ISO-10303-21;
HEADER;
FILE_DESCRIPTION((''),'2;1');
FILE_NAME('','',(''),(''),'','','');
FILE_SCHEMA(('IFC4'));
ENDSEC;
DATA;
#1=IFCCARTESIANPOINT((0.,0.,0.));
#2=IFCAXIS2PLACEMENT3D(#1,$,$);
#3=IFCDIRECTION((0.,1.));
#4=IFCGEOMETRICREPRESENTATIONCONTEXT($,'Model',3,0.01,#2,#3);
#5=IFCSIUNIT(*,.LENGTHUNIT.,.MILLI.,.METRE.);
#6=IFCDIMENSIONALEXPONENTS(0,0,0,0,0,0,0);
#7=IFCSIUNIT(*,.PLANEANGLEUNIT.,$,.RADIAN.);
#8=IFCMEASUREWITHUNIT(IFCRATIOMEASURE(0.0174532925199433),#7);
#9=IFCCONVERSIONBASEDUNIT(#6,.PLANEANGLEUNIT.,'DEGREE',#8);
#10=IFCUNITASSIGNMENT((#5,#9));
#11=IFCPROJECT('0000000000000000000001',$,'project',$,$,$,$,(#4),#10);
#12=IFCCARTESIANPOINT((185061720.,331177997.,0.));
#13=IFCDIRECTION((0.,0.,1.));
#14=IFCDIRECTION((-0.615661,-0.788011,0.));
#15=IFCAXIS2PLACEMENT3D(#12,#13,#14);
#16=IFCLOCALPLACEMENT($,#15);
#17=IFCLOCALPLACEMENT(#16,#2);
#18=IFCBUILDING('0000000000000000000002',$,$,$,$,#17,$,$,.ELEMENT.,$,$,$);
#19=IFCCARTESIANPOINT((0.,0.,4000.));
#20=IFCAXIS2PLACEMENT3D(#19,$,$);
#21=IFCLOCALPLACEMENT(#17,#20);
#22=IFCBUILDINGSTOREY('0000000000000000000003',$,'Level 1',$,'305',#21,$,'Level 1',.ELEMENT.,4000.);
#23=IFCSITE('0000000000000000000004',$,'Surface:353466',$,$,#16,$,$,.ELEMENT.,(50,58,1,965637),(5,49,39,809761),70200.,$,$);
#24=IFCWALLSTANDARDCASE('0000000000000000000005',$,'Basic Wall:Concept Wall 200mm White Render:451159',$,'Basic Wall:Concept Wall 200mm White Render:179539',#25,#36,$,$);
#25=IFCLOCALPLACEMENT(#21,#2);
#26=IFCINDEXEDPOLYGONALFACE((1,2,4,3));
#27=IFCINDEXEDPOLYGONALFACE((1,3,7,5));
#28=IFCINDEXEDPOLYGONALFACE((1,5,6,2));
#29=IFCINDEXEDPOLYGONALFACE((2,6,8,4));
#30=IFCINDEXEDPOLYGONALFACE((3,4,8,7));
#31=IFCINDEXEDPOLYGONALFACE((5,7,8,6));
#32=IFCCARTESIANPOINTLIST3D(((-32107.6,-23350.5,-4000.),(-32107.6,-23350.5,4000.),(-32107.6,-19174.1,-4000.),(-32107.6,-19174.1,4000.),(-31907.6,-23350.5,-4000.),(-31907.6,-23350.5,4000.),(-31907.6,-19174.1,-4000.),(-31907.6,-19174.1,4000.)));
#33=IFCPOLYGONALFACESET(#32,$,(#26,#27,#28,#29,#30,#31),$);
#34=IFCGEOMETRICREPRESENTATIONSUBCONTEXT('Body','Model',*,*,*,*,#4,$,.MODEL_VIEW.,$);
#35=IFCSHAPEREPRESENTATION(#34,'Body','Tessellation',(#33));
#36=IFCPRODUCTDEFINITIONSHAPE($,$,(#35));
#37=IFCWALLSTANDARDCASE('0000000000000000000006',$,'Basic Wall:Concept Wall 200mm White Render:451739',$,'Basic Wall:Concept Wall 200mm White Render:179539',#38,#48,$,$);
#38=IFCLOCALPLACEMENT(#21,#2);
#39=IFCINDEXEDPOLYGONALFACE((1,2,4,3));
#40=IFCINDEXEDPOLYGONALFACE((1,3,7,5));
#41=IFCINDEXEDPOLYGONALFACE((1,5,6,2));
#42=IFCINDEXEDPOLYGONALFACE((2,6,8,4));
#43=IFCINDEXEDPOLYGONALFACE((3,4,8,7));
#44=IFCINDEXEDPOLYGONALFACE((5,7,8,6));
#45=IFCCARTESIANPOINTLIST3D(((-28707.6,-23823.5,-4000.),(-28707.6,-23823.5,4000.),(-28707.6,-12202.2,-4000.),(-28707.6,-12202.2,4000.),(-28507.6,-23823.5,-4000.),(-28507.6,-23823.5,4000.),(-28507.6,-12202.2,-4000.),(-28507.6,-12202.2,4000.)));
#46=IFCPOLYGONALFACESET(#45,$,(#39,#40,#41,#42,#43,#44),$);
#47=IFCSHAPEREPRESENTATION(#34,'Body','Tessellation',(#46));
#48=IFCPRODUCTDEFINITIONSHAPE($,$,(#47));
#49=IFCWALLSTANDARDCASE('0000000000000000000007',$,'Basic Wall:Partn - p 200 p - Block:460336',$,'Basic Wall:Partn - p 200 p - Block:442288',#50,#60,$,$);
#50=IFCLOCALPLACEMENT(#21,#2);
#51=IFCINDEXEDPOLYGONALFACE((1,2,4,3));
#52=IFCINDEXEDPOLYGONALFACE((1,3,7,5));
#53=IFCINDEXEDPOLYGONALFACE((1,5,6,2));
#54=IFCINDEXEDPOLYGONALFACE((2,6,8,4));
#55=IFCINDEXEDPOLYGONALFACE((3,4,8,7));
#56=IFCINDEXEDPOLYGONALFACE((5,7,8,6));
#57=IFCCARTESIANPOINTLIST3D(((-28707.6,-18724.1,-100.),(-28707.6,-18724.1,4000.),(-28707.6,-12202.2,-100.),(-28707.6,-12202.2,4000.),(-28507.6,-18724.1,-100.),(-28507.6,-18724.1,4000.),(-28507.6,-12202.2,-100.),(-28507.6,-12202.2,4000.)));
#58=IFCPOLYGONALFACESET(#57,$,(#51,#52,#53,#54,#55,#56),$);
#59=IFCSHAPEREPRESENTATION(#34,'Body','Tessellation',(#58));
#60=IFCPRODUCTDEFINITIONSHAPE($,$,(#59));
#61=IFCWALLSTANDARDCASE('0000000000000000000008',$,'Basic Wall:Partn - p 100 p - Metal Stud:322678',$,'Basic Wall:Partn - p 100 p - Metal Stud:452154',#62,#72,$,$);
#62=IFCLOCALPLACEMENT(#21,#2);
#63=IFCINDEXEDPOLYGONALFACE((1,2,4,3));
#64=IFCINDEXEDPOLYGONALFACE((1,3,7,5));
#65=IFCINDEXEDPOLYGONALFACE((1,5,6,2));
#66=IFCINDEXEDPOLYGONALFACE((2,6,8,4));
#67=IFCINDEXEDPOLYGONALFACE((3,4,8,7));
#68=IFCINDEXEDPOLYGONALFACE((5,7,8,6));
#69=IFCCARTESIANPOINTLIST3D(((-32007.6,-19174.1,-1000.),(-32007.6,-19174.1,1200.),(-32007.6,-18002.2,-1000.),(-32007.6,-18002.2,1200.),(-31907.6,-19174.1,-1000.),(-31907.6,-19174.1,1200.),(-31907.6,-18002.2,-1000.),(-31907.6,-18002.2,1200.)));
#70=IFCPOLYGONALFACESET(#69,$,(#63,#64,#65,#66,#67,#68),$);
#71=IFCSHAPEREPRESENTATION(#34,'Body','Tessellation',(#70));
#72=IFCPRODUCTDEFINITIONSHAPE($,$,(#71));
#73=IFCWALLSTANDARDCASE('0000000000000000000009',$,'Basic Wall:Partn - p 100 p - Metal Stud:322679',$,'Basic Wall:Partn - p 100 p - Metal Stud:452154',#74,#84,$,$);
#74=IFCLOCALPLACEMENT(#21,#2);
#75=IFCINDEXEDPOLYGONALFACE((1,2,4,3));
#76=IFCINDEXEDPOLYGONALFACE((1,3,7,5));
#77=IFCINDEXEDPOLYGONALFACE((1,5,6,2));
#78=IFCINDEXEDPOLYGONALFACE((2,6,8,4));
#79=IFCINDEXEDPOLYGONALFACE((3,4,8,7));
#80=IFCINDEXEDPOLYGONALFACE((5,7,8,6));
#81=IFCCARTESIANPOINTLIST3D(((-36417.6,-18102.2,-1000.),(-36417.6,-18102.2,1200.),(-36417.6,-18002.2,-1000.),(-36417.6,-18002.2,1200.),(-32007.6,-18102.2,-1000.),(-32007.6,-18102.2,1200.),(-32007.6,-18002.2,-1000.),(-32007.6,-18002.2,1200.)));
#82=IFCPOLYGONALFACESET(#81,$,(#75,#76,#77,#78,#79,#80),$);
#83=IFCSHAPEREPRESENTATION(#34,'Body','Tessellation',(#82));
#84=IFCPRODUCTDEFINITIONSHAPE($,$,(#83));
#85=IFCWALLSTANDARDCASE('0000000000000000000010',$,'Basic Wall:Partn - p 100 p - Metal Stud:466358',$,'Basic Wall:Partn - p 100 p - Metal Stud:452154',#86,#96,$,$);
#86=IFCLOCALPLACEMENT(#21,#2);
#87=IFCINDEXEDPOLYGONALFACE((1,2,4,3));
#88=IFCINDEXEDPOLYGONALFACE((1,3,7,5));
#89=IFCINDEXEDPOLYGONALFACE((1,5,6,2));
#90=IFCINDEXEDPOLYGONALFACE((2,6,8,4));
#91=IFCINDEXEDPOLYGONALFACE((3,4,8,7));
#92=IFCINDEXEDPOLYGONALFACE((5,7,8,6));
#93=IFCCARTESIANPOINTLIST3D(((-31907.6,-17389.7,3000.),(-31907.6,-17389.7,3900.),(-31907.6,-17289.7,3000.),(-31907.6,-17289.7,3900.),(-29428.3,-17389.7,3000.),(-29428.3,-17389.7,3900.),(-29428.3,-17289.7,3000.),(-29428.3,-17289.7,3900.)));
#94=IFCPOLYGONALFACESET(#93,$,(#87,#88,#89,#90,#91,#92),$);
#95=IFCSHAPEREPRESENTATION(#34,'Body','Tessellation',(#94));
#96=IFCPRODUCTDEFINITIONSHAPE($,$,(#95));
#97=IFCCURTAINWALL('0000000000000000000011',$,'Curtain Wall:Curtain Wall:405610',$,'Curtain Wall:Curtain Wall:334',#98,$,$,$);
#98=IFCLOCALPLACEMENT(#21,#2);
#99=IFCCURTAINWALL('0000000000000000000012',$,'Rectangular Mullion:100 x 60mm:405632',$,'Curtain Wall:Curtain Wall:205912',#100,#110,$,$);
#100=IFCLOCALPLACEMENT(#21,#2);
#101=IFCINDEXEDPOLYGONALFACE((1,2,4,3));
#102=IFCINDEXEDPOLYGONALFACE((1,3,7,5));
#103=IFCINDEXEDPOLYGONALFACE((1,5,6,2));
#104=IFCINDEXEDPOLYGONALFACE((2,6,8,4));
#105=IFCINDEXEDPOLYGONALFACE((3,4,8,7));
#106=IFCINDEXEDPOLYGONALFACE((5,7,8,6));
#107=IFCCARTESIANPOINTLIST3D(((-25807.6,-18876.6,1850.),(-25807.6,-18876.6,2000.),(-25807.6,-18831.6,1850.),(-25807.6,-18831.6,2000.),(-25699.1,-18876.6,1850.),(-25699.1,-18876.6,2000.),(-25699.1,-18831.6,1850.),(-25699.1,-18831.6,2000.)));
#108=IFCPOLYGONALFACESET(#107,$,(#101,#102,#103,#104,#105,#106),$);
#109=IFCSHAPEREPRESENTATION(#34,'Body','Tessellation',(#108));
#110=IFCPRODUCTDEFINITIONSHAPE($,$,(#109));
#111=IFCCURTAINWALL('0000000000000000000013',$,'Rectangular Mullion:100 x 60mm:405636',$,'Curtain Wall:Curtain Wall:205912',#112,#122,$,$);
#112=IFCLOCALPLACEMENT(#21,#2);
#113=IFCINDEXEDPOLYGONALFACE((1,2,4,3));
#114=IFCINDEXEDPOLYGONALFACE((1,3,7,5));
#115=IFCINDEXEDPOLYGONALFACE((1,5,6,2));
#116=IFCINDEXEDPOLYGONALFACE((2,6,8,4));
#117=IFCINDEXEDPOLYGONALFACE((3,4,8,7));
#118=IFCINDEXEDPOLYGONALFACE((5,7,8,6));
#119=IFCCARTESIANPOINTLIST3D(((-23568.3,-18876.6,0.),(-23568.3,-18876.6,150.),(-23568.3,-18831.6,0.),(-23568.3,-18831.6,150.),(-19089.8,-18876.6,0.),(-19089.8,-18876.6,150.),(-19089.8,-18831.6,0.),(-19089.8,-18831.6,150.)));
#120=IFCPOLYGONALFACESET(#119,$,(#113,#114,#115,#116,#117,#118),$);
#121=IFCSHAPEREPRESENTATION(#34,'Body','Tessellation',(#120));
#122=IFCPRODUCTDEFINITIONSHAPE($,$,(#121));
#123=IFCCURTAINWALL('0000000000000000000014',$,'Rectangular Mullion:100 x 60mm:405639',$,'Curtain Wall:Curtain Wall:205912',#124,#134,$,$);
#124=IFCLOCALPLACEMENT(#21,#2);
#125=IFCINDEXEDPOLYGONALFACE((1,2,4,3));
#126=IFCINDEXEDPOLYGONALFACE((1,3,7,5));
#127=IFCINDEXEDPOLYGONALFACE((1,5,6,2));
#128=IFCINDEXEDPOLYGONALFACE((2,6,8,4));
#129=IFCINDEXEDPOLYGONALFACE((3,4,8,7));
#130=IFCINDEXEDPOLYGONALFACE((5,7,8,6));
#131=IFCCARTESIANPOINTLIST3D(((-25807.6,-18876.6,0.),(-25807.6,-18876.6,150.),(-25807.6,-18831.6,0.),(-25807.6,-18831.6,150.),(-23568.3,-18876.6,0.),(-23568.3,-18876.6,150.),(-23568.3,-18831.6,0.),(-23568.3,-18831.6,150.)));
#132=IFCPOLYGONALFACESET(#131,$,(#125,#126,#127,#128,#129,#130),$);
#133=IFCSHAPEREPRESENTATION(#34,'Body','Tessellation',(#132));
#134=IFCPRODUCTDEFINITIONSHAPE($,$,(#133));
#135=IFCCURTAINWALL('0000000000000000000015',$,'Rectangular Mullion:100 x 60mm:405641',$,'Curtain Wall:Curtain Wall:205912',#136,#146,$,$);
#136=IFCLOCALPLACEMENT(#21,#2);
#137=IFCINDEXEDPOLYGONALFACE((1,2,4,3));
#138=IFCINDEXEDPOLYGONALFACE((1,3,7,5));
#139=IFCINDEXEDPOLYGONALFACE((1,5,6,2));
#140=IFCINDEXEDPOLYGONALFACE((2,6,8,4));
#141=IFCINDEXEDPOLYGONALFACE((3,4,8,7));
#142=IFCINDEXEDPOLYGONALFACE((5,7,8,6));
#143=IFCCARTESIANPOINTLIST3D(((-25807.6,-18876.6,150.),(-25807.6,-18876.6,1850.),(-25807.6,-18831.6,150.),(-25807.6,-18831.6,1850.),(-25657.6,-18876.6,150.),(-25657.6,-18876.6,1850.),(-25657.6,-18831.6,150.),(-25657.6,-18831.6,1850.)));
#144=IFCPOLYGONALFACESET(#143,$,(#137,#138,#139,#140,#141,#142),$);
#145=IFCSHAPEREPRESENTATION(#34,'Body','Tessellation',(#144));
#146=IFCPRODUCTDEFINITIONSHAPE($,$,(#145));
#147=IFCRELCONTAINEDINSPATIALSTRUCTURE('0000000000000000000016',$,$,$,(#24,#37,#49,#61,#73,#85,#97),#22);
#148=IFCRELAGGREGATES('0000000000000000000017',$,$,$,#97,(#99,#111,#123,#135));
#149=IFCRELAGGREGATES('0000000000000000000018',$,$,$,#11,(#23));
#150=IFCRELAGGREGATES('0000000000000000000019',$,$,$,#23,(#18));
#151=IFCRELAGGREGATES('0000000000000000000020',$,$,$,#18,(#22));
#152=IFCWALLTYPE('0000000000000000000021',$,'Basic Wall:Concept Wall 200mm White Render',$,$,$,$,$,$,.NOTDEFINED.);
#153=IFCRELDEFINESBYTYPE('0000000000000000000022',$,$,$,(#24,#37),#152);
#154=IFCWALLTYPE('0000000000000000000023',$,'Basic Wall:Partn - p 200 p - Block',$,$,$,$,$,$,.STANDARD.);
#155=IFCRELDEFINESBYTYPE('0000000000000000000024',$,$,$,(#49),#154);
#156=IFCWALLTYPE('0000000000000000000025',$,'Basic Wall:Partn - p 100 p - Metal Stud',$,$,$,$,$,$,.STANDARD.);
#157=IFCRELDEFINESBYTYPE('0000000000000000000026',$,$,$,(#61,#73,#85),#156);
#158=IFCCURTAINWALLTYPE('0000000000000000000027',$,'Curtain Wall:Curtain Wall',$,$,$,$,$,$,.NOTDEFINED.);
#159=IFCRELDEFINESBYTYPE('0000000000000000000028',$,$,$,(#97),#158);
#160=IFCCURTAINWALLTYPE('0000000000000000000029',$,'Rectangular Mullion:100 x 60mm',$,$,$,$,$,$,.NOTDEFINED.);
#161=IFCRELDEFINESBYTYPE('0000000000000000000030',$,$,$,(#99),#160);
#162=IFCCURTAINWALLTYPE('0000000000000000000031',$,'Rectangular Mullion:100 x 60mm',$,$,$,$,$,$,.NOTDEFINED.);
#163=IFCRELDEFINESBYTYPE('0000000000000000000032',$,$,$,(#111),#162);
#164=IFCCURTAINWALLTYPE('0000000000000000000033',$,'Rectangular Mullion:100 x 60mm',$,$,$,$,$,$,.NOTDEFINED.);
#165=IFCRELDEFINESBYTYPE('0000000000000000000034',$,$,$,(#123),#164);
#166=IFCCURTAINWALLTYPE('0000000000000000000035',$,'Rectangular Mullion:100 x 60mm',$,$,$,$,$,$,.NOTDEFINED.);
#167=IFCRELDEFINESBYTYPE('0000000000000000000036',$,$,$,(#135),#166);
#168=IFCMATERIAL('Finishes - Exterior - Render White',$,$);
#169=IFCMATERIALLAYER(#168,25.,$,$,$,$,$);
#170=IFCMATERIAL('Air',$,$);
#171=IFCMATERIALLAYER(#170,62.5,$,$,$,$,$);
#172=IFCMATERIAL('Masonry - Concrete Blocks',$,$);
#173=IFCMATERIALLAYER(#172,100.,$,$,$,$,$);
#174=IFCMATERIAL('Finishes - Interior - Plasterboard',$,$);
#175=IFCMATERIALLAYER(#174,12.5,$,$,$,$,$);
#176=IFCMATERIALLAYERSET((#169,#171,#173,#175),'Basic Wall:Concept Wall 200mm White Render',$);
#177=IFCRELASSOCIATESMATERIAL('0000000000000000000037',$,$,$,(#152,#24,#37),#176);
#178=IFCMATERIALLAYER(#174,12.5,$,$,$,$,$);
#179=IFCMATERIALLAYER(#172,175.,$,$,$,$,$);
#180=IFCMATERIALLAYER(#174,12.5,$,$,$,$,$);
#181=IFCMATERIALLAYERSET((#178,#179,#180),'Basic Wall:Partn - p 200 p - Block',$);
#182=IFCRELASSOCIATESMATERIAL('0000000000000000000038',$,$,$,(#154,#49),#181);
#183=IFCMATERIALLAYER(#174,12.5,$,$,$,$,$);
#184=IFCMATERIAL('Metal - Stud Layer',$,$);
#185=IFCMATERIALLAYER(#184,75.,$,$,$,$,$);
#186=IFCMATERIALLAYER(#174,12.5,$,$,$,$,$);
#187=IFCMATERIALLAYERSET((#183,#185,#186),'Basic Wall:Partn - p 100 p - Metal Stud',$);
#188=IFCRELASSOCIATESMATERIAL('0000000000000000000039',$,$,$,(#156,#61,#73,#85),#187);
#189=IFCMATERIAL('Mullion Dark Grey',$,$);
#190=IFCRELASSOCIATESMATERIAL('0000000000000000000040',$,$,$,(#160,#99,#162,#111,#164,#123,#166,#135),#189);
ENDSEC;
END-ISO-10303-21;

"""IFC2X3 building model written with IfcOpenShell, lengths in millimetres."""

from ifc_helpers import new_model, entity, si_unit, converted_unit, direction, frame, frame_2d, origin, place, context, subcontext, project, spatial, rectangle, extrude, clip, halfspace, source, transform, mapped, material, layer, layer_set, layer_usage, type_object, type_shapes, element, aggregate, save


model = new_model("IFC2X3")

# Units and contexts
model_context = context("Model", 3, precision=0.01, world=origin(), true_north=direction((0.0, 1.0)))
body_context = subcontext(model_context, "Body", "Model", "MODEL_VIEW")
ifc_project = project(units=[si_unit("LENGTHUNIT", "METRE", prefix="MILLI"), converted_unit("PLANEANGLEUNIT", "DEGREE", entity("IfcRatioMeasure", 0.0174532925199433), si_unit("PLANEANGLEUNIT", "RADIAN"), dimensions=[0, 0, 0, 0, 0, 0, 0])], contexts=[model_context])

# Site, building, storey
site_placement = place(None, frame((185061720.0, 331177997.0, 0.0), z_axis=(0.0, 0.0, 1.0), x_axis=(-0.615661, -0.788011, 0.0)))
site = spatial("IfcSite", under=ifc_project, at=site_placement, Name="Surface:353466", CompositionType="ELEMENT", RefLatitude=(50, 58, 1, 965637), RefLongitude=(5, 49, 39, 809761), RefElevation=70200.0)
building_placement = place(site_placement, origin())
building = spatial("IfcBuilding", under=site, at=building_placement, CompositionType="ELEMENT")
storey_placement = place(building_placement, frame((0.0, 0.0, 4000.0)))
storey = spatial("IfcBuildingStorey", under=building, at=storey_placement, Name="Level 1", ObjectType="305", LongName="Level 1", CompositionType="ELEMENT", Elevation=4000.0)

# Shared definitions
ifc_material_1 = material(Name="Masonry - Concrete Blocks")
ifc_material_2 = material(Name="Finishes - Interior - Plasterboard")

# Walls
ifc_material_3 = material(Name="Finishes - Exterior - Render White")
ifc_layer_1 = layer(ifc_material_3, 25.0)
ifc_material_4 = material(Name="Air")
ifc_layer_2 = layer(ifc_material_4, 62.5)
ifc_layer_3 = layer(ifc_material_1, 100.0)
ifc_layer_4 = layer(ifc_material_2, 12.5)
ifc_layer_set_1 = layer_set([ifc_layer_1, ifc_layer_2, ifc_layer_3, ifc_layer_4], Name="Basic Wall:Concept Wall 200mm White Render")
ifc_layer_usage_1 = layer_usage(ifc_layer_set_1, "AXIS2", "POSITIVE", -100.0)
wall_type_1 = type_object("IfcWallType", Name="Basic Wall:Concept Wall 200mm White Render", PredefinedType="NOTDEFINED", material=ifc_layer_set_1)
wall_1_placement = place(storey_placement, frame((-32007.6, -19174.1, -4000.0), z_axis=(0.0, 0.0, 1.0), x_axis=(0.0, -1.0, 0.0)))
element("IfcWallStandardCase", 1, at=wall_1_placement, inside=storey, type_object=wall_type_1, material=ifc_layer_usage_1, Name="Basic Wall:Concept Wall 200mm White Render:451159", ObjectType="Basic Wall:Concept Wall 200mm White Render:179539", context=body_context, shape_type="Clipping", body=[
    clip(extrude(rectangle(XDim=4176.4, YDim=200.0, at=frame_2d((2088.2, 0.0), x_axis=(-1.0, 0.0))), origin(), (0.0, 0.0, 1.0), 8000.0), halfspace(frame((0.0, 0.0, -4000.0)), True)),
])
ifc_layer_usage_2 = layer_usage(ifc_layer_set_1, "AXIS2", "POSITIVE", -100.0)
wall_2_placement = place(storey_placement, frame((-28607.6, -23823.5, -4000.0), z_axis=(0.0, 0.0, 1.0), x_axis=(0.0, 1.0, 0.0)))
element("IfcWallStandardCase", 2, at=wall_2_placement, inside=storey, type_object=wall_type_1, material=ifc_layer_usage_2, Name="Basic Wall:Concept Wall 200mm White Render:451739", ObjectType="Basic Wall:Concept Wall 200mm White Render:179539", context=body_context, shape_type="Clipping", body=[
    clip(extrude(rectangle(XDim=11621.2, YDim=200.0, at=frame_2d((5810.6, 0.0), x_axis=(-1.0, 0.0))), origin(), (0.0, 0.0, 1.0), 8000.0), halfspace(frame((0.0, 0.0, -4000.0)), True)),
])
ifc_layer_5 = layer(ifc_material_2, 12.5)
ifc_layer_6 = layer(ifc_material_1, 175.0)
ifc_layer_7 = layer(ifc_material_2, 12.5)
ifc_layer_set_2 = layer_set([ifc_layer_5, ifc_layer_6, ifc_layer_7], Name="Basic Wall:Partn - p 200 p - Block")
ifc_layer_usage_3 = layer_usage(ifc_layer_set_2, "AXIS2", "POSITIVE", -100.0)
wall_type_2 = type_object("IfcWallType", Name="Basic Wall:Partn - p 200 p - Block", PredefinedType="STANDARD", material=ifc_layer_set_2)
wall_3_placement = place(storey_placement, frame((-28607.6, -18724.1, -100.0), z_axis=(0.0, 0.0, 1.0), x_axis=(0.0, 1.0, 0.0)))
element("IfcWallStandardCase", 3, at=wall_3_placement, inside=storey, type_object=wall_type_2, material=ifc_layer_usage_3, Name="Basic Wall:Partn - p 200 p - Block:460336", ObjectType="Basic Wall:Partn - p 200 p - Block:442288", context=body_context, shape_type="Clipping", body=[
    clip(extrude(rectangle(XDim=6521.9, YDim=200.0, at=frame_2d((3261.0, 0.0), x_axis=(-1.0, 0.0))), origin(), (0.0, 0.0, 1.0), 4100.0), halfspace(frame((0.0, 0.0, -100.0)), True)),
])
ifc_layer_8 = layer(ifc_material_2, 12.5)
ifc_material_5 = material(Name="Metal - Stud Layer")
ifc_layer_9 = layer(ifc_material_5, 75.0)
ifc_layer_10 = layer(ifc_material_2, 12.5)
ifc_layer_set_3 = layer_set([ifc_layer_8, ifc_layer_9, ifc_layer_10], Name="Basic Wall:Partn - p 100 p - Metal Stud")
ifc_layer_usage_4 = layer_usage(ifc_layer_set_3, "AXIS2", "NEGATIVE", 50.0)
wall_type_3 = type_object("IfcWallType", Name="Basic Wall:Partn - p 100 p - Metal Stud", PredefinedType="STANDARD", material=ifc_layer_set_3)
wall_4_placement = place(storey_placement, frame((-31957.6, -19174.1, -1000.0), z_axis=(0.0, 0.0, 1.0), x_axis=(0.0, 1.0, 0.0)))
element("IfcWallStandardCase", 4, at=wall_4_placement, inside=storey, type_object=wall_type_3, material=ifc_layer_usage_4, Name="Basic Wall:Partn - p 100 p - Metal Stud:322678", ObjectType="Basic Wall:Partn - p 100 p - Metal Stud:452154", context=body_context, shape_type="SweptSolid", body=[
    extrude(rectangle(XDim=1171.9, YDim=100.0, at=frame_2d((586.0, 0.0), x_axis=(-1.0, 0.0))), origin(), (0.0, 0.0, 1.0), 2200.0),
])
ifc_layer_usage_5 = layer_usage(ifc_layer_set_3, "AXIS2", "NEGATIVE", 50.0)
wall_5_placement = place(storey_placement, frame((-32007.6, -18052.2, -1000.0), z_axis=(0.0, 0.0, 1.0), x_axis=(-1.0, 0.0, 0.0)))
element("IfcWallStandardCase", 5, at=wall_5_placement, inside=storey, type_object=wall_type_3, material=ifc_layer_usage_5, Name="Basic Wall:Partn - p 100 p - Metal Stud:322679", ObjectType="Basic Wall:Partn - p 100 p - Metal Stud:452154", context=body_context, shape_type="SweptSolid", body=[
    extrude(rectangle(XDim=4410.0, YDim=100.0, at=frame_2d((2205.0, 0.0), x_axis=(-1.0, 0.0))), origin(), (0.0, 0.0, 1.0), 2200.0),
])
ifc_layer_usage_6 = layer_usage(ifc_layer_set_3, "AXIS2", "NEGATIVE", 50.0)
wall_6_placement = place(storey_placement, frame((-29428.3, -17339.7, 3000.0), z_axis=(0.0, 0.0, 1.0), x_axis=(-1.0, 0.0, 0.0)))
element("IfcWallStandardCase", 6, at=wall_6_placement, inside=storey, type_object=wall_type_3, material=ifc_layer_usage_6, Name="Basic Wall:Partn - p 100 p - Metal Stud:466358", ObjectType="Basic Wall:Partn - p 100 p - Metal Stud:452154", context=body_context, shape_type="SweptSolid", body=[
    extrude(rectangle(XDim=2479.3, YDim=100.0, at=frame_2d((1239.6, 0.0), x_axis=(-1.0, 0.0))), origin(), (0.0, 0.0, 1.0), 900.0),
])

# Curtain walls
curtain_wall_type_1 = type_object("IfcCurtainWallType", Name="Curtain Wall:Curtain Wall", PredefinedType="NOTDEFINED")
curtain_wall_1_placement = place(storey_placement, frame((0.0, 0.0, -4000.0)))
curtain_wall_1 = element("IfcCurtainWall", 7, at=curtain_wall_1_placement, inside=storey, type_object=curtain_wall_type_1, Name="Curtain Wall:Curtain Wall:405610", ObjectType="Curtain Wall:Curtain Wall:334")
ifc_material_6 = material(Name="Mullion Dark Grey")
curtain_wall_type_2 = type_object("IfcCurtainWallType", Name="Rectangular Mullion:100 x 60mm", PredefinedType="NOTDEFINED", material=ifc_material_6)
shared_shape_1 = source(origin(), body_context, "Body", "SweptSolid", [
    extrude(rectangle(XDim=150.0, YDim=45.0, at=frame_2d((0.0, 0.0), x_axis=(1.0, 0.0))), frame((-75.0, -7.5, -108.5)), (0.0, 0.0, 1.0), 108.5),
])
type_shapes(curtain_wall_type_2, [shared_shape_1])
curtain_wall_2_placement = place(storey_placement, frame((-25699.1, -18861.6, 2000.0), z_axis=(1.0, 0.0, 0.0), x_axis=(0.0, 0.0, 1.0)))
curtain_wall_2 = element("IfcCurtainWall", 8, at=curtain_wall_2_placement, type_object=curtain_wall_type_2, material=ifc_material_6, Name="Rectangular Mullion:100 x 60mm:405632", ObjectType="Curtain Wall:Curtain Wall:205912", context=body_context, shape_type="MappedRepresentation", body=[
    mapped(shared_shape_1, transform((0.0, 0.0, 0.0), scale=1.0)),
])
curtain_wall_type_3 = type_object("IfcCurtainWallType", Name="Rectangular Mullion:100 x 60mm", PredefinedType="NOTDEFINED", material=ifc_material_6)
shared_shape_2 = source(origin(), body_context, "Body", "SweptSolid", [
    extrude(rectangle(XDim=45.0, YDim=150.0, at=frame_2d((0.0, 0.0), x_axis=(1.0, 0.0))), frame((-75.0, -7.5, -4478.5), z_axis=(0.0, 0.0, 1.0), x_axis=(0.0, 1.0, 0.0)), (0.0, 0.0, 1.0), 4478.5),
])
type_shapes(curtain_wall_type_3, [shared_shape_2])
curtain_wall_3_placement = place(storey_placement, frame((-23568.3, -18861.6, 0.0), z_axis=(-1.0, 0.0, 0.0), x_axis=(0.0, 0.0, -1.0)))
curtain_wall_3 = element("IfcCurtainWall", 9, at=curtain_wall_3_placement, type_object=curtain_wall_type_3, material=ifc_material_6, Name="Rectangular Mullion:100 x 60mm:405636", ObjectType="Curtain Wall:Curtain Wall:205912", context=body_context, shape_type="MappedRepresentation", body=[
    mapped(shared_shape_2, transform((0.0, 0.0, 0.0), scale=1.0)),
])
curtain_wall_type_4 = type_object("IfcCurtainWallType", Name="Rectangular Mullion:100 x 60mm", PredefinedType="NOTDEFINED", material=ifc_material_6)
shared_shape_3 = source(origin(), body_context, "Body", "SweptSolid", [
    extrude(rectangle(XDim=45.0, YDim=150.0, at=frame_2d((0.0, 0.0), x_axis=(1.0, 0.0))), frame((-75.0, -7.5, -2239.3), z_axis=(0.0, 0.0, 1.0), x_axis=(0.0, 1.0, 0.0)), (0.0, 0.0, 1.0), 2239.3),
])
type_shapes(curtain_wall_type_4, [shared_shape_3])
curtain_wall_4_placement = place(storey_placement, frame((-25807.6, -18861.6, 0.0), z_axis=(-1.0, 0.0, 0.0), x_axis=(0.0, 0.0, -1.0)))
curtain_wall_4 = element("IfcCurtainWall", 10, at=curtain_wall_4_placement, type_object=curtain_wall_type_4, material=ifc_material_6, Name="Rectangular Mullion:100 x 60mm:405639", ObjectType="Curtain Wall:Curtain Wall:205912", context=body_context, shape_type="MappedRepresentation", body=[
    mapped(shared_shape_3, transform((0.0, 0.0, 0.0), scale=1.0)),
])
curtain_wall_type_5 = type_object("IfcCurtainWallType", Name="Rectangular Mullion:100 x 60mm", PredefinedType="NOTDEFINED", material=ifc_material_6)
shared_shape_4 = source(origin(), body_context, "Body", "SweptSolid", [
    extrude(rectangle(XDim=45.0, YDim=150.0, at=frame_2d((0.0, 0.0), x_axis=(1.0, 0.0))), frame((-75.0, -7.5, -1700.0), z_axis=(0.0, 0.0, 1.0), x_axis=(0.0, 1.0, 0.0)), (0.0, 0.0, 1.0), 1700.0),
])
type_shapes(curtain_wall_type_5, [shared_shape_4])
curtain_wall_5_placement = place(storey_placement, frame((-25807.6, -18861.6, 1850.0), z_axis=(0.0, 0.0, 1.0), x_axis=(-1.0, 0.0, 0.0)))
curtain_wall_5 = element("IfcCurtainWall", 11, at=curtain_wall_5_placement, type_object=curtain_wall_type_5, material=ifc_material_6, Name="Rectangular Mullion:100 x 60mm:405641", ObjectType="Curtain Wall:Curtain Wall:205912", context=body_context, shape_type="MappedRepresentation", body=[
    mapped(shared_shape_4, transform((0.0, 0.0, 0.0), scale=1.0)),
])
aggregate(curtain_wall_1, [curtain_wall_2, curtain_wall_3, curtain_wall_4, curtain_wall_5])

save(model, "model.ifc")
